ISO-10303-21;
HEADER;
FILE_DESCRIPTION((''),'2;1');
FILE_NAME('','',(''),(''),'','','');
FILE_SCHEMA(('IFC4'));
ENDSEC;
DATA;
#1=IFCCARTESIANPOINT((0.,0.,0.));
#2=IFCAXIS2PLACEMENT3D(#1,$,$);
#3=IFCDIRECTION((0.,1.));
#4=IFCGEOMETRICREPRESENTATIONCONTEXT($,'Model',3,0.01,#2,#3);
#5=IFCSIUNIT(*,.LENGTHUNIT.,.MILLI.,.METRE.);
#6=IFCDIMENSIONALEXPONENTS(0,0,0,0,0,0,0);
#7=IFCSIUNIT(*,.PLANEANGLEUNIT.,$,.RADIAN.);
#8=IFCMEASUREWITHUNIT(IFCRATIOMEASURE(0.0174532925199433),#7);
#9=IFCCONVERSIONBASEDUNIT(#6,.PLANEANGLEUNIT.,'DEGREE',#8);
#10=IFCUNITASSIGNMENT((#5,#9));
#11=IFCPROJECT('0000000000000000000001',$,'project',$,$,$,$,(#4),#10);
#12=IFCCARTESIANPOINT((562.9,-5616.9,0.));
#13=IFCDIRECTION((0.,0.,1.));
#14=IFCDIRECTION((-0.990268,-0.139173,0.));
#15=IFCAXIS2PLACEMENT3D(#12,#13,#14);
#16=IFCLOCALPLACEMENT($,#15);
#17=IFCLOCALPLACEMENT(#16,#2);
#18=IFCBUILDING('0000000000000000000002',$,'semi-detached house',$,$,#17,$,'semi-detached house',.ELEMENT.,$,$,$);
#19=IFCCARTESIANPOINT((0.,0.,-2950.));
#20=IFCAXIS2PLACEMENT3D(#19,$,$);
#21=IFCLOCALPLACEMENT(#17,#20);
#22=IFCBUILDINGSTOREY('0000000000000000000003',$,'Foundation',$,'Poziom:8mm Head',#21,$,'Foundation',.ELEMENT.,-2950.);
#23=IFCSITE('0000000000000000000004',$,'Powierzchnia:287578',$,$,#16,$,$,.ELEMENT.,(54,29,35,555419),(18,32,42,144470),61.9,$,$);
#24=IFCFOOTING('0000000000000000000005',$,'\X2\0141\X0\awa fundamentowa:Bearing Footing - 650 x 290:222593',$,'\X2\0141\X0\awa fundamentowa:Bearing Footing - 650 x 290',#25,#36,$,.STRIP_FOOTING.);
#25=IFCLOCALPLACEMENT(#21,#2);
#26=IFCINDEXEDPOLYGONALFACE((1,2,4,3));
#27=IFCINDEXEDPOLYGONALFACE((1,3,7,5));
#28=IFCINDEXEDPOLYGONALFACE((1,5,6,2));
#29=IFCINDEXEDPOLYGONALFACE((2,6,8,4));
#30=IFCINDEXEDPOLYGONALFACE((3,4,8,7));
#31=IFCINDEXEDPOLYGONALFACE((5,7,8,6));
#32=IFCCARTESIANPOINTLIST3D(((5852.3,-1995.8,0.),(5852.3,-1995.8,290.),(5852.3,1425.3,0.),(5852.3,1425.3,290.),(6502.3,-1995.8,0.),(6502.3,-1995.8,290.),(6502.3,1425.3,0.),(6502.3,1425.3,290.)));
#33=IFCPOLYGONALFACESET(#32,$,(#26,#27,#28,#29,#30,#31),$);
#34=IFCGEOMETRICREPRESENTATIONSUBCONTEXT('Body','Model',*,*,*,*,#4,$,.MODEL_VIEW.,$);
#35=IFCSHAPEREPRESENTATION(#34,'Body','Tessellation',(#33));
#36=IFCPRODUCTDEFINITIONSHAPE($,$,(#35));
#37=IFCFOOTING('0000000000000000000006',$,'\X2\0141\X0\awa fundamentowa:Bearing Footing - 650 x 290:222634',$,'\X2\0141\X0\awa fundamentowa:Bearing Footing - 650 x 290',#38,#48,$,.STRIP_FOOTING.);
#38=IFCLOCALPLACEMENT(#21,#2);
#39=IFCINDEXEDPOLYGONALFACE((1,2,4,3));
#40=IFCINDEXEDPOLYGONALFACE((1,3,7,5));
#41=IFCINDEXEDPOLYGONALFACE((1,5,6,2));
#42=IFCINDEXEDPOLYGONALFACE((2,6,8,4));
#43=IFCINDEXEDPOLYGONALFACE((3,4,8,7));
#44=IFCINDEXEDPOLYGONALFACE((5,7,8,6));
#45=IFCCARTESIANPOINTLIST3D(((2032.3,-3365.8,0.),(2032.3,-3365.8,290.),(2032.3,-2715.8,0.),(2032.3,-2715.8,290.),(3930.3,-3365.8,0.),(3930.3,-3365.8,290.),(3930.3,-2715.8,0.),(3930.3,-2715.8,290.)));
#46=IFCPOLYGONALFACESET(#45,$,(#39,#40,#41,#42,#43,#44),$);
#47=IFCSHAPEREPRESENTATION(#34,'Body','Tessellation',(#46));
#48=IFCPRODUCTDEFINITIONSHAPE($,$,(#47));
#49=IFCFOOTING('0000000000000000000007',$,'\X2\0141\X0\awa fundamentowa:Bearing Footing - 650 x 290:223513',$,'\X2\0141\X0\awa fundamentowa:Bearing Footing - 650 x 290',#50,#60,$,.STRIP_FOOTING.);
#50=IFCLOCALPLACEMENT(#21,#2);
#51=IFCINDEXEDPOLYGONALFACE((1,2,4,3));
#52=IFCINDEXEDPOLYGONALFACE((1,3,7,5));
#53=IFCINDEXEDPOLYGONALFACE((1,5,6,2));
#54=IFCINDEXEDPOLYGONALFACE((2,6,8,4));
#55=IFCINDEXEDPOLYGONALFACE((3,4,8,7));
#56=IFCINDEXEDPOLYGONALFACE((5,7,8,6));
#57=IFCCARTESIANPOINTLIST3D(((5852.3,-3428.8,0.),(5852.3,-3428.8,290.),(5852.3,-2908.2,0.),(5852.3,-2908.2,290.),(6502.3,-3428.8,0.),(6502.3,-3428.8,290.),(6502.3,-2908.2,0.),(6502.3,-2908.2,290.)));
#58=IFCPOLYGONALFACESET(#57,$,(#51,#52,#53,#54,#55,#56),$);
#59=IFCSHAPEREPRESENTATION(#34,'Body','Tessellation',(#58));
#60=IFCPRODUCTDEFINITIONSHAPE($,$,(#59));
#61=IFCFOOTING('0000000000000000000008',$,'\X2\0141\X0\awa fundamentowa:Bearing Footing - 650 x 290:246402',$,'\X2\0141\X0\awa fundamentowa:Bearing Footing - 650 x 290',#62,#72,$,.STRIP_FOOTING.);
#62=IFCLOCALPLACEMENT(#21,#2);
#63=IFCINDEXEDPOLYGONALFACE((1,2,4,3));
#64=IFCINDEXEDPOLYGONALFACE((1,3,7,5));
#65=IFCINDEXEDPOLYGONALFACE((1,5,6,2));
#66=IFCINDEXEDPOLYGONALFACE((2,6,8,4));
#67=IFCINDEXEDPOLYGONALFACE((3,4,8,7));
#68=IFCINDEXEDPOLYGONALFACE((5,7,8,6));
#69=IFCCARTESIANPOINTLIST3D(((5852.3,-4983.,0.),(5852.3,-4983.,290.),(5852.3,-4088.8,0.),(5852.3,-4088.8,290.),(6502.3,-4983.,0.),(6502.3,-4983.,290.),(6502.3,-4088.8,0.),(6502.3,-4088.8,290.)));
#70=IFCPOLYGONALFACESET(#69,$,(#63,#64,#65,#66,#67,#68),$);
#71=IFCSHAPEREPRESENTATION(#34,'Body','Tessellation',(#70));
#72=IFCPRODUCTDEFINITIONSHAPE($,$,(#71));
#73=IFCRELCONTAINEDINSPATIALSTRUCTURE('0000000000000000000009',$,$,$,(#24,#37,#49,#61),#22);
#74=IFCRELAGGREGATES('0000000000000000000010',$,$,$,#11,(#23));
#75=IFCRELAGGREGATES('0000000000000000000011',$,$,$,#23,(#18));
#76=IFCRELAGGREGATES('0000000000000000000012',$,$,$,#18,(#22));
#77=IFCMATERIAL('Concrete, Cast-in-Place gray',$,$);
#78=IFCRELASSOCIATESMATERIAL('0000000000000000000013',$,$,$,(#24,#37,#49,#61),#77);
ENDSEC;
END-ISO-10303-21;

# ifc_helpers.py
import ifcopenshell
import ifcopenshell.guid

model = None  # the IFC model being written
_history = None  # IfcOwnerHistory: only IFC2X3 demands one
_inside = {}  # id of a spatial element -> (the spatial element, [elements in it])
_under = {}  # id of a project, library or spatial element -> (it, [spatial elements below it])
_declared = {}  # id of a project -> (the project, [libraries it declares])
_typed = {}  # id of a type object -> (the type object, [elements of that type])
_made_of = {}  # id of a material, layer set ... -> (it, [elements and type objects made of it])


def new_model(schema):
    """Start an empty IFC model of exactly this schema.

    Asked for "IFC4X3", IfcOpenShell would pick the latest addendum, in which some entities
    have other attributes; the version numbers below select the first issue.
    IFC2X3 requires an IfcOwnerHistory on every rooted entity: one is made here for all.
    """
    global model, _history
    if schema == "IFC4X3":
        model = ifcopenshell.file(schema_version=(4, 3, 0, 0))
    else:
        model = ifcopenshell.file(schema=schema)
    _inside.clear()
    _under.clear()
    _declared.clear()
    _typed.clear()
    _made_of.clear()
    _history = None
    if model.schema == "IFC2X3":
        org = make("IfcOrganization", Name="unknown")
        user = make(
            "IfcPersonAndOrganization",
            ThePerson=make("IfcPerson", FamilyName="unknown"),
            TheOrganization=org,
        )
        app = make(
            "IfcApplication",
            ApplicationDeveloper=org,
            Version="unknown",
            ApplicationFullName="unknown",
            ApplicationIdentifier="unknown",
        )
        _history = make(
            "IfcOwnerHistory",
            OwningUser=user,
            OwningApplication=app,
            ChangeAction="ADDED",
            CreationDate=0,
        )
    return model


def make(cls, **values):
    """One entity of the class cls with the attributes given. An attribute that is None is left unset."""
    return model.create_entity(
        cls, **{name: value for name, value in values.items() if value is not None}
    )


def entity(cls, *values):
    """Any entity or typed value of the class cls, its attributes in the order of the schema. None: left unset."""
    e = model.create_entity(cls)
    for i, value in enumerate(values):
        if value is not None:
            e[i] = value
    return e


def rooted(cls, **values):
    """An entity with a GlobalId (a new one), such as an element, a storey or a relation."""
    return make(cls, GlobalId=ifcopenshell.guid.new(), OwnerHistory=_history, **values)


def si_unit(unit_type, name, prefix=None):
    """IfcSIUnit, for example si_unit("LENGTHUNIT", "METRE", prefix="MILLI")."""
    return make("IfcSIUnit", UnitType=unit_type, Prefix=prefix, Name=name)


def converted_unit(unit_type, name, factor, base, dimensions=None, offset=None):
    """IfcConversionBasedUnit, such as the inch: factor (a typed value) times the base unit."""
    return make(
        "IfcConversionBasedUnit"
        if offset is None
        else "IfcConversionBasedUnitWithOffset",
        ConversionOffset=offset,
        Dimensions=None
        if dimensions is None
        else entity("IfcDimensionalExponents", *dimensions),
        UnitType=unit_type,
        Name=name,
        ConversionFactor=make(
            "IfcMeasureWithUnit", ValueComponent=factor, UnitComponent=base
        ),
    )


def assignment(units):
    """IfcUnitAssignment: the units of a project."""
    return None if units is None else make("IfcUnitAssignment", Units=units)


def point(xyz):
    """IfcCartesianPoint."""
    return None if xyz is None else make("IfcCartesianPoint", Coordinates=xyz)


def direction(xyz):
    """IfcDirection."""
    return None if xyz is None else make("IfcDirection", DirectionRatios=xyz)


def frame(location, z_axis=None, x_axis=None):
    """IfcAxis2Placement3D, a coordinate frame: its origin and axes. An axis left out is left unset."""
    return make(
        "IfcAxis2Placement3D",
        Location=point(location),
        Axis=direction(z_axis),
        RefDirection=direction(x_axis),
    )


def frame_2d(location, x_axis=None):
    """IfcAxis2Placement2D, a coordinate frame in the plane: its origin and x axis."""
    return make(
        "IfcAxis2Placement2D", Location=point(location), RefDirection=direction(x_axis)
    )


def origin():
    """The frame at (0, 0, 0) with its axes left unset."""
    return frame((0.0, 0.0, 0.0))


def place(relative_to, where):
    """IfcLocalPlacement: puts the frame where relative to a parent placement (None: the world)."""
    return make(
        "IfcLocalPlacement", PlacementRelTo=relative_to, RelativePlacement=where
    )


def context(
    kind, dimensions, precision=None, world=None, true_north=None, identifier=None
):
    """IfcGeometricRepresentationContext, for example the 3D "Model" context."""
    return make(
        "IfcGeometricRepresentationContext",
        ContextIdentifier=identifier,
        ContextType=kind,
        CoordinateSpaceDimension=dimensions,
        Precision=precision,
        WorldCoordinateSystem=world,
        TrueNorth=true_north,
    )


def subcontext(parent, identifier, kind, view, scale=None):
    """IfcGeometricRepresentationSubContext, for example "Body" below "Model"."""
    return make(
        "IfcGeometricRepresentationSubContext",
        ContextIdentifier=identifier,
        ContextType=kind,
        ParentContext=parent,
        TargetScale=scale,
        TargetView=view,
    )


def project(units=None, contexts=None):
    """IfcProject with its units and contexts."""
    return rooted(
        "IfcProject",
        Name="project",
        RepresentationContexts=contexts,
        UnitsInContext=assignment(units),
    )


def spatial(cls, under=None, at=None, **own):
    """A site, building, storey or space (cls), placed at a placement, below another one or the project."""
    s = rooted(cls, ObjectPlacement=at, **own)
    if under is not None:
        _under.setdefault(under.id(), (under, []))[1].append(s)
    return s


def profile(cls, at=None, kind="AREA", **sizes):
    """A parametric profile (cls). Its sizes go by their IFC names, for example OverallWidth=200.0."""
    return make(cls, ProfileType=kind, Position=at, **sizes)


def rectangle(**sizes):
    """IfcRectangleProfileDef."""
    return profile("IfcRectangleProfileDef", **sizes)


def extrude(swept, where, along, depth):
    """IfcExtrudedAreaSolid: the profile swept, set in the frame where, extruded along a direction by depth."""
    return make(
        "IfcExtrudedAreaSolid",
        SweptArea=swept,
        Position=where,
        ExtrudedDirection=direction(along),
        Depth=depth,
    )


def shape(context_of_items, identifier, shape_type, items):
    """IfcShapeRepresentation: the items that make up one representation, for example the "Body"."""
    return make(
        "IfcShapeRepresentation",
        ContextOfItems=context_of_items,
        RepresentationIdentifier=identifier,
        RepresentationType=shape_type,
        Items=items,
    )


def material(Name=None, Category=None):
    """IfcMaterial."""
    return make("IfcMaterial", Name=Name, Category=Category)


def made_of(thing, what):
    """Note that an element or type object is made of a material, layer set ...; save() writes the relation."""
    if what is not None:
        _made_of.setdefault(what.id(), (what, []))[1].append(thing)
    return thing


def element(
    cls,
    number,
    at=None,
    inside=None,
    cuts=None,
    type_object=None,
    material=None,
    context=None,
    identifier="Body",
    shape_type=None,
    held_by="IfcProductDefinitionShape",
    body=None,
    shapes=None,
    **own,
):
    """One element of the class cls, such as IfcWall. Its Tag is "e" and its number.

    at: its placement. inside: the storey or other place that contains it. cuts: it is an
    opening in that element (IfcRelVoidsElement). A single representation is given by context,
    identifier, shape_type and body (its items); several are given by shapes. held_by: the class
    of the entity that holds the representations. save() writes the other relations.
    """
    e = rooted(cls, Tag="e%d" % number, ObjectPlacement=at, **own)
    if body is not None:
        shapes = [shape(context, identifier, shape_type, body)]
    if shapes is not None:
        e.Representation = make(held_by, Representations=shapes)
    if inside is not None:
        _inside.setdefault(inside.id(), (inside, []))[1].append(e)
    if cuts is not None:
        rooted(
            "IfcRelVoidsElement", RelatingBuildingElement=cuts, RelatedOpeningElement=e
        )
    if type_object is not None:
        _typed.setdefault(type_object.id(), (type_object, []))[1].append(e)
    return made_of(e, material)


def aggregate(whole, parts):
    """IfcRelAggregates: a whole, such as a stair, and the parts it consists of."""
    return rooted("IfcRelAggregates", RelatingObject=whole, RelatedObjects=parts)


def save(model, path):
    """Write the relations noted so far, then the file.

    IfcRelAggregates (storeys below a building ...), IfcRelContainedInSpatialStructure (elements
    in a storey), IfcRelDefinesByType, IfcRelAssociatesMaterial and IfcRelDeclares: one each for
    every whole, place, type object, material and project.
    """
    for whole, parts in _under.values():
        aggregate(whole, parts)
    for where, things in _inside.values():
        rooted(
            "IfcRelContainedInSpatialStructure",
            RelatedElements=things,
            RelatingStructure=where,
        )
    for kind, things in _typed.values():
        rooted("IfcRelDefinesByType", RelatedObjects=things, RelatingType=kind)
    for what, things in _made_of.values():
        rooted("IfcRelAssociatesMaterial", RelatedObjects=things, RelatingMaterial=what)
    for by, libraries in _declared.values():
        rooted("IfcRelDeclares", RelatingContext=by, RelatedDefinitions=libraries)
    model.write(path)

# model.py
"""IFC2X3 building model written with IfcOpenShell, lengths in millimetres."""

from ifc_helpers import new_model, entity, si_unit, converted_unit, direction, frame, frame_2d, origin, place, context, subcontext, project, spatial, rectangle, extrude, material, element, save


model = new_model("IFC2X3")

# Units and contexts
model_context = context("Model", 3, precision=0.01, world=origin(), true_north=direction((0.0, 1.0)))
body_context = subcontext(model_context, "Body", "Model", "MODEL_VIEW")
ifc_project = project(units=[si_unit("LENGTHUNIT", "METRE", prefix="MILLI"), converted_unit("PLANEANGLEUNIT", "DEGREE", entity("IfcRatioMeasure", 0.0174532925199433), si_unit("PLANEANGLEUNIT", "RADIAN"), dimensions=[0, 0, 0, 0, 0, 0, 0])], contexts=[model_context])

# Site, building, storey
site_placement = place(None, frame((562.9, -5616.9, 0.0), z_axis=(0.0, 0.0, 1.0), x_axis=(-0.990268, -0.139173, 0.0)))
site = spatial("IfcSite", under=ifc_project, at=site_placement, Name="Powierzchnia:287578", CompositionType="ELEMENT", RefLatitude=(54, 29, 35, 555419), RefLongitude=(18, 32, 42, 144470), RefElevation=61.9)
building_placement = place(site_placement, origin())
building = spatial("IfcBuilding", under=site, at=building_placement, Name="semi-detached house", LongName="semi-detached house", CompositionType="ELEMENT")
storey_placement = place(building_placement, frame((0.0, 0.0, -2950.0)))
storey = spatial("IfcBuildingStorey", under=building, at=storey_placement, Name="Foundation", ObjectType="Poziom:8mm Head", LongName="Foundation", CompositionType="ELEMENT", Elevation=-2950.0)

# Footings
ifc_material = material(Name="Concrete, Cast-in-Place gray")
footing_1_placement = place(storey_placement, origin())
element("IfcFooting", 1, at=footing_1_placement, inside=storey, material=ifc_material, Name="Ława fundamentowa:Bearing Footing - 650 x 290:222593", ObjectType="Ława fundamentowa:Bearing Footing - 650 x 290", PredefinedType="STRIP_FOOTING", context=body_context, shape_type="SweptSolid", body=[
    extrude(rectangle(XDim=3421.1, YDim=650.0, at=frame_2d((0.0, 0.0), x_axis=(1.0, 0.0))), frame((6177.3, -285.2, 0.0), z_axis=(0.0, 0.0, 1.0), x_axis=(0.0, -1.0, 0.0)), (0.0, 0.0, 1.0), 290.0),
])
footing_2_placement = place(storey_placement, origin())
element("IfcFooting", 2, at=footing_2_placement, inside=storey, material=ifc_material, Name="Ława fundamentowa:Bearing Footing - 650 x 290:222634", ObjectType="Ława fundamentowa:Bearing Footing - 650 x 290", PredefinedType="STRIP_FOOTING", context=body_context, shape_type="SweptSolid", body=[
    extrude(rectangle(XDim=1898.0, YDim=650.0, at=frame_2d((0.0, 0.0), x_axis=(1.0, 0.0))), frame((2981.3, -3040.8, 0.0), z_axis=(0.0, 0.0, 1.0), x_axis=(-1.0, 0.0, 0.0)), (0.0, 0.0, 1.0), 290.0),
])
footing_3_placement = place(storey_placement, origin())
element("IfcFooting", 3, at=footing_3_placement, inside=storey, material=ifc_material, Name="Ława fundamentowa:Bearing Footing - 650 x 290:223513", ObjectType="Ława fundamentowa:Bearing Footing - 650 x 290", PredefinedType="STRIP_FOOTING", context=body_context, shape_type="SweptSolid", body=[
    extrude(rectangle(XDim=520.6, YDim=650.0, at=frame_2d((0.0, 0.0), x_axis=(1.0, 0.0))), frame((6177.3, -3168.5, 0.0), z_axis=(0.0, 0.0, 1.0), x_axis=(0.0, -1.0, 0.0)), (0.0, 0.0, 1.0), 290.0),
])
footing_4_placement = place(storey_placement, origin())
element("IfcFooting", 4, at=footing_4_placement, inside=storey, material=ifc_material, Name="Ława fundamentowa:Bearing Footing - 650 x 290:246402", ObjectType="Ława fundamentowa:Bearing Footing - 650 x 290", PredefinedType="STRIP_FOOTING", context=body_context, shape_type="SweptSolid", body=[
    extrude(rectangle(XDim=894.2, YDim=650.0, at=frame_2d((0.0, 0.0), x_axis=(1.0, 0.0))), frame((6177.3, -4535.9, 0.0), z_axis=(0.0, 0.0, 1.0), x_axis=(0.0, -1.0, 0.0)), (0.0, 0.0, 1.0), 290.0),
])

save(model, "model.ifc")
